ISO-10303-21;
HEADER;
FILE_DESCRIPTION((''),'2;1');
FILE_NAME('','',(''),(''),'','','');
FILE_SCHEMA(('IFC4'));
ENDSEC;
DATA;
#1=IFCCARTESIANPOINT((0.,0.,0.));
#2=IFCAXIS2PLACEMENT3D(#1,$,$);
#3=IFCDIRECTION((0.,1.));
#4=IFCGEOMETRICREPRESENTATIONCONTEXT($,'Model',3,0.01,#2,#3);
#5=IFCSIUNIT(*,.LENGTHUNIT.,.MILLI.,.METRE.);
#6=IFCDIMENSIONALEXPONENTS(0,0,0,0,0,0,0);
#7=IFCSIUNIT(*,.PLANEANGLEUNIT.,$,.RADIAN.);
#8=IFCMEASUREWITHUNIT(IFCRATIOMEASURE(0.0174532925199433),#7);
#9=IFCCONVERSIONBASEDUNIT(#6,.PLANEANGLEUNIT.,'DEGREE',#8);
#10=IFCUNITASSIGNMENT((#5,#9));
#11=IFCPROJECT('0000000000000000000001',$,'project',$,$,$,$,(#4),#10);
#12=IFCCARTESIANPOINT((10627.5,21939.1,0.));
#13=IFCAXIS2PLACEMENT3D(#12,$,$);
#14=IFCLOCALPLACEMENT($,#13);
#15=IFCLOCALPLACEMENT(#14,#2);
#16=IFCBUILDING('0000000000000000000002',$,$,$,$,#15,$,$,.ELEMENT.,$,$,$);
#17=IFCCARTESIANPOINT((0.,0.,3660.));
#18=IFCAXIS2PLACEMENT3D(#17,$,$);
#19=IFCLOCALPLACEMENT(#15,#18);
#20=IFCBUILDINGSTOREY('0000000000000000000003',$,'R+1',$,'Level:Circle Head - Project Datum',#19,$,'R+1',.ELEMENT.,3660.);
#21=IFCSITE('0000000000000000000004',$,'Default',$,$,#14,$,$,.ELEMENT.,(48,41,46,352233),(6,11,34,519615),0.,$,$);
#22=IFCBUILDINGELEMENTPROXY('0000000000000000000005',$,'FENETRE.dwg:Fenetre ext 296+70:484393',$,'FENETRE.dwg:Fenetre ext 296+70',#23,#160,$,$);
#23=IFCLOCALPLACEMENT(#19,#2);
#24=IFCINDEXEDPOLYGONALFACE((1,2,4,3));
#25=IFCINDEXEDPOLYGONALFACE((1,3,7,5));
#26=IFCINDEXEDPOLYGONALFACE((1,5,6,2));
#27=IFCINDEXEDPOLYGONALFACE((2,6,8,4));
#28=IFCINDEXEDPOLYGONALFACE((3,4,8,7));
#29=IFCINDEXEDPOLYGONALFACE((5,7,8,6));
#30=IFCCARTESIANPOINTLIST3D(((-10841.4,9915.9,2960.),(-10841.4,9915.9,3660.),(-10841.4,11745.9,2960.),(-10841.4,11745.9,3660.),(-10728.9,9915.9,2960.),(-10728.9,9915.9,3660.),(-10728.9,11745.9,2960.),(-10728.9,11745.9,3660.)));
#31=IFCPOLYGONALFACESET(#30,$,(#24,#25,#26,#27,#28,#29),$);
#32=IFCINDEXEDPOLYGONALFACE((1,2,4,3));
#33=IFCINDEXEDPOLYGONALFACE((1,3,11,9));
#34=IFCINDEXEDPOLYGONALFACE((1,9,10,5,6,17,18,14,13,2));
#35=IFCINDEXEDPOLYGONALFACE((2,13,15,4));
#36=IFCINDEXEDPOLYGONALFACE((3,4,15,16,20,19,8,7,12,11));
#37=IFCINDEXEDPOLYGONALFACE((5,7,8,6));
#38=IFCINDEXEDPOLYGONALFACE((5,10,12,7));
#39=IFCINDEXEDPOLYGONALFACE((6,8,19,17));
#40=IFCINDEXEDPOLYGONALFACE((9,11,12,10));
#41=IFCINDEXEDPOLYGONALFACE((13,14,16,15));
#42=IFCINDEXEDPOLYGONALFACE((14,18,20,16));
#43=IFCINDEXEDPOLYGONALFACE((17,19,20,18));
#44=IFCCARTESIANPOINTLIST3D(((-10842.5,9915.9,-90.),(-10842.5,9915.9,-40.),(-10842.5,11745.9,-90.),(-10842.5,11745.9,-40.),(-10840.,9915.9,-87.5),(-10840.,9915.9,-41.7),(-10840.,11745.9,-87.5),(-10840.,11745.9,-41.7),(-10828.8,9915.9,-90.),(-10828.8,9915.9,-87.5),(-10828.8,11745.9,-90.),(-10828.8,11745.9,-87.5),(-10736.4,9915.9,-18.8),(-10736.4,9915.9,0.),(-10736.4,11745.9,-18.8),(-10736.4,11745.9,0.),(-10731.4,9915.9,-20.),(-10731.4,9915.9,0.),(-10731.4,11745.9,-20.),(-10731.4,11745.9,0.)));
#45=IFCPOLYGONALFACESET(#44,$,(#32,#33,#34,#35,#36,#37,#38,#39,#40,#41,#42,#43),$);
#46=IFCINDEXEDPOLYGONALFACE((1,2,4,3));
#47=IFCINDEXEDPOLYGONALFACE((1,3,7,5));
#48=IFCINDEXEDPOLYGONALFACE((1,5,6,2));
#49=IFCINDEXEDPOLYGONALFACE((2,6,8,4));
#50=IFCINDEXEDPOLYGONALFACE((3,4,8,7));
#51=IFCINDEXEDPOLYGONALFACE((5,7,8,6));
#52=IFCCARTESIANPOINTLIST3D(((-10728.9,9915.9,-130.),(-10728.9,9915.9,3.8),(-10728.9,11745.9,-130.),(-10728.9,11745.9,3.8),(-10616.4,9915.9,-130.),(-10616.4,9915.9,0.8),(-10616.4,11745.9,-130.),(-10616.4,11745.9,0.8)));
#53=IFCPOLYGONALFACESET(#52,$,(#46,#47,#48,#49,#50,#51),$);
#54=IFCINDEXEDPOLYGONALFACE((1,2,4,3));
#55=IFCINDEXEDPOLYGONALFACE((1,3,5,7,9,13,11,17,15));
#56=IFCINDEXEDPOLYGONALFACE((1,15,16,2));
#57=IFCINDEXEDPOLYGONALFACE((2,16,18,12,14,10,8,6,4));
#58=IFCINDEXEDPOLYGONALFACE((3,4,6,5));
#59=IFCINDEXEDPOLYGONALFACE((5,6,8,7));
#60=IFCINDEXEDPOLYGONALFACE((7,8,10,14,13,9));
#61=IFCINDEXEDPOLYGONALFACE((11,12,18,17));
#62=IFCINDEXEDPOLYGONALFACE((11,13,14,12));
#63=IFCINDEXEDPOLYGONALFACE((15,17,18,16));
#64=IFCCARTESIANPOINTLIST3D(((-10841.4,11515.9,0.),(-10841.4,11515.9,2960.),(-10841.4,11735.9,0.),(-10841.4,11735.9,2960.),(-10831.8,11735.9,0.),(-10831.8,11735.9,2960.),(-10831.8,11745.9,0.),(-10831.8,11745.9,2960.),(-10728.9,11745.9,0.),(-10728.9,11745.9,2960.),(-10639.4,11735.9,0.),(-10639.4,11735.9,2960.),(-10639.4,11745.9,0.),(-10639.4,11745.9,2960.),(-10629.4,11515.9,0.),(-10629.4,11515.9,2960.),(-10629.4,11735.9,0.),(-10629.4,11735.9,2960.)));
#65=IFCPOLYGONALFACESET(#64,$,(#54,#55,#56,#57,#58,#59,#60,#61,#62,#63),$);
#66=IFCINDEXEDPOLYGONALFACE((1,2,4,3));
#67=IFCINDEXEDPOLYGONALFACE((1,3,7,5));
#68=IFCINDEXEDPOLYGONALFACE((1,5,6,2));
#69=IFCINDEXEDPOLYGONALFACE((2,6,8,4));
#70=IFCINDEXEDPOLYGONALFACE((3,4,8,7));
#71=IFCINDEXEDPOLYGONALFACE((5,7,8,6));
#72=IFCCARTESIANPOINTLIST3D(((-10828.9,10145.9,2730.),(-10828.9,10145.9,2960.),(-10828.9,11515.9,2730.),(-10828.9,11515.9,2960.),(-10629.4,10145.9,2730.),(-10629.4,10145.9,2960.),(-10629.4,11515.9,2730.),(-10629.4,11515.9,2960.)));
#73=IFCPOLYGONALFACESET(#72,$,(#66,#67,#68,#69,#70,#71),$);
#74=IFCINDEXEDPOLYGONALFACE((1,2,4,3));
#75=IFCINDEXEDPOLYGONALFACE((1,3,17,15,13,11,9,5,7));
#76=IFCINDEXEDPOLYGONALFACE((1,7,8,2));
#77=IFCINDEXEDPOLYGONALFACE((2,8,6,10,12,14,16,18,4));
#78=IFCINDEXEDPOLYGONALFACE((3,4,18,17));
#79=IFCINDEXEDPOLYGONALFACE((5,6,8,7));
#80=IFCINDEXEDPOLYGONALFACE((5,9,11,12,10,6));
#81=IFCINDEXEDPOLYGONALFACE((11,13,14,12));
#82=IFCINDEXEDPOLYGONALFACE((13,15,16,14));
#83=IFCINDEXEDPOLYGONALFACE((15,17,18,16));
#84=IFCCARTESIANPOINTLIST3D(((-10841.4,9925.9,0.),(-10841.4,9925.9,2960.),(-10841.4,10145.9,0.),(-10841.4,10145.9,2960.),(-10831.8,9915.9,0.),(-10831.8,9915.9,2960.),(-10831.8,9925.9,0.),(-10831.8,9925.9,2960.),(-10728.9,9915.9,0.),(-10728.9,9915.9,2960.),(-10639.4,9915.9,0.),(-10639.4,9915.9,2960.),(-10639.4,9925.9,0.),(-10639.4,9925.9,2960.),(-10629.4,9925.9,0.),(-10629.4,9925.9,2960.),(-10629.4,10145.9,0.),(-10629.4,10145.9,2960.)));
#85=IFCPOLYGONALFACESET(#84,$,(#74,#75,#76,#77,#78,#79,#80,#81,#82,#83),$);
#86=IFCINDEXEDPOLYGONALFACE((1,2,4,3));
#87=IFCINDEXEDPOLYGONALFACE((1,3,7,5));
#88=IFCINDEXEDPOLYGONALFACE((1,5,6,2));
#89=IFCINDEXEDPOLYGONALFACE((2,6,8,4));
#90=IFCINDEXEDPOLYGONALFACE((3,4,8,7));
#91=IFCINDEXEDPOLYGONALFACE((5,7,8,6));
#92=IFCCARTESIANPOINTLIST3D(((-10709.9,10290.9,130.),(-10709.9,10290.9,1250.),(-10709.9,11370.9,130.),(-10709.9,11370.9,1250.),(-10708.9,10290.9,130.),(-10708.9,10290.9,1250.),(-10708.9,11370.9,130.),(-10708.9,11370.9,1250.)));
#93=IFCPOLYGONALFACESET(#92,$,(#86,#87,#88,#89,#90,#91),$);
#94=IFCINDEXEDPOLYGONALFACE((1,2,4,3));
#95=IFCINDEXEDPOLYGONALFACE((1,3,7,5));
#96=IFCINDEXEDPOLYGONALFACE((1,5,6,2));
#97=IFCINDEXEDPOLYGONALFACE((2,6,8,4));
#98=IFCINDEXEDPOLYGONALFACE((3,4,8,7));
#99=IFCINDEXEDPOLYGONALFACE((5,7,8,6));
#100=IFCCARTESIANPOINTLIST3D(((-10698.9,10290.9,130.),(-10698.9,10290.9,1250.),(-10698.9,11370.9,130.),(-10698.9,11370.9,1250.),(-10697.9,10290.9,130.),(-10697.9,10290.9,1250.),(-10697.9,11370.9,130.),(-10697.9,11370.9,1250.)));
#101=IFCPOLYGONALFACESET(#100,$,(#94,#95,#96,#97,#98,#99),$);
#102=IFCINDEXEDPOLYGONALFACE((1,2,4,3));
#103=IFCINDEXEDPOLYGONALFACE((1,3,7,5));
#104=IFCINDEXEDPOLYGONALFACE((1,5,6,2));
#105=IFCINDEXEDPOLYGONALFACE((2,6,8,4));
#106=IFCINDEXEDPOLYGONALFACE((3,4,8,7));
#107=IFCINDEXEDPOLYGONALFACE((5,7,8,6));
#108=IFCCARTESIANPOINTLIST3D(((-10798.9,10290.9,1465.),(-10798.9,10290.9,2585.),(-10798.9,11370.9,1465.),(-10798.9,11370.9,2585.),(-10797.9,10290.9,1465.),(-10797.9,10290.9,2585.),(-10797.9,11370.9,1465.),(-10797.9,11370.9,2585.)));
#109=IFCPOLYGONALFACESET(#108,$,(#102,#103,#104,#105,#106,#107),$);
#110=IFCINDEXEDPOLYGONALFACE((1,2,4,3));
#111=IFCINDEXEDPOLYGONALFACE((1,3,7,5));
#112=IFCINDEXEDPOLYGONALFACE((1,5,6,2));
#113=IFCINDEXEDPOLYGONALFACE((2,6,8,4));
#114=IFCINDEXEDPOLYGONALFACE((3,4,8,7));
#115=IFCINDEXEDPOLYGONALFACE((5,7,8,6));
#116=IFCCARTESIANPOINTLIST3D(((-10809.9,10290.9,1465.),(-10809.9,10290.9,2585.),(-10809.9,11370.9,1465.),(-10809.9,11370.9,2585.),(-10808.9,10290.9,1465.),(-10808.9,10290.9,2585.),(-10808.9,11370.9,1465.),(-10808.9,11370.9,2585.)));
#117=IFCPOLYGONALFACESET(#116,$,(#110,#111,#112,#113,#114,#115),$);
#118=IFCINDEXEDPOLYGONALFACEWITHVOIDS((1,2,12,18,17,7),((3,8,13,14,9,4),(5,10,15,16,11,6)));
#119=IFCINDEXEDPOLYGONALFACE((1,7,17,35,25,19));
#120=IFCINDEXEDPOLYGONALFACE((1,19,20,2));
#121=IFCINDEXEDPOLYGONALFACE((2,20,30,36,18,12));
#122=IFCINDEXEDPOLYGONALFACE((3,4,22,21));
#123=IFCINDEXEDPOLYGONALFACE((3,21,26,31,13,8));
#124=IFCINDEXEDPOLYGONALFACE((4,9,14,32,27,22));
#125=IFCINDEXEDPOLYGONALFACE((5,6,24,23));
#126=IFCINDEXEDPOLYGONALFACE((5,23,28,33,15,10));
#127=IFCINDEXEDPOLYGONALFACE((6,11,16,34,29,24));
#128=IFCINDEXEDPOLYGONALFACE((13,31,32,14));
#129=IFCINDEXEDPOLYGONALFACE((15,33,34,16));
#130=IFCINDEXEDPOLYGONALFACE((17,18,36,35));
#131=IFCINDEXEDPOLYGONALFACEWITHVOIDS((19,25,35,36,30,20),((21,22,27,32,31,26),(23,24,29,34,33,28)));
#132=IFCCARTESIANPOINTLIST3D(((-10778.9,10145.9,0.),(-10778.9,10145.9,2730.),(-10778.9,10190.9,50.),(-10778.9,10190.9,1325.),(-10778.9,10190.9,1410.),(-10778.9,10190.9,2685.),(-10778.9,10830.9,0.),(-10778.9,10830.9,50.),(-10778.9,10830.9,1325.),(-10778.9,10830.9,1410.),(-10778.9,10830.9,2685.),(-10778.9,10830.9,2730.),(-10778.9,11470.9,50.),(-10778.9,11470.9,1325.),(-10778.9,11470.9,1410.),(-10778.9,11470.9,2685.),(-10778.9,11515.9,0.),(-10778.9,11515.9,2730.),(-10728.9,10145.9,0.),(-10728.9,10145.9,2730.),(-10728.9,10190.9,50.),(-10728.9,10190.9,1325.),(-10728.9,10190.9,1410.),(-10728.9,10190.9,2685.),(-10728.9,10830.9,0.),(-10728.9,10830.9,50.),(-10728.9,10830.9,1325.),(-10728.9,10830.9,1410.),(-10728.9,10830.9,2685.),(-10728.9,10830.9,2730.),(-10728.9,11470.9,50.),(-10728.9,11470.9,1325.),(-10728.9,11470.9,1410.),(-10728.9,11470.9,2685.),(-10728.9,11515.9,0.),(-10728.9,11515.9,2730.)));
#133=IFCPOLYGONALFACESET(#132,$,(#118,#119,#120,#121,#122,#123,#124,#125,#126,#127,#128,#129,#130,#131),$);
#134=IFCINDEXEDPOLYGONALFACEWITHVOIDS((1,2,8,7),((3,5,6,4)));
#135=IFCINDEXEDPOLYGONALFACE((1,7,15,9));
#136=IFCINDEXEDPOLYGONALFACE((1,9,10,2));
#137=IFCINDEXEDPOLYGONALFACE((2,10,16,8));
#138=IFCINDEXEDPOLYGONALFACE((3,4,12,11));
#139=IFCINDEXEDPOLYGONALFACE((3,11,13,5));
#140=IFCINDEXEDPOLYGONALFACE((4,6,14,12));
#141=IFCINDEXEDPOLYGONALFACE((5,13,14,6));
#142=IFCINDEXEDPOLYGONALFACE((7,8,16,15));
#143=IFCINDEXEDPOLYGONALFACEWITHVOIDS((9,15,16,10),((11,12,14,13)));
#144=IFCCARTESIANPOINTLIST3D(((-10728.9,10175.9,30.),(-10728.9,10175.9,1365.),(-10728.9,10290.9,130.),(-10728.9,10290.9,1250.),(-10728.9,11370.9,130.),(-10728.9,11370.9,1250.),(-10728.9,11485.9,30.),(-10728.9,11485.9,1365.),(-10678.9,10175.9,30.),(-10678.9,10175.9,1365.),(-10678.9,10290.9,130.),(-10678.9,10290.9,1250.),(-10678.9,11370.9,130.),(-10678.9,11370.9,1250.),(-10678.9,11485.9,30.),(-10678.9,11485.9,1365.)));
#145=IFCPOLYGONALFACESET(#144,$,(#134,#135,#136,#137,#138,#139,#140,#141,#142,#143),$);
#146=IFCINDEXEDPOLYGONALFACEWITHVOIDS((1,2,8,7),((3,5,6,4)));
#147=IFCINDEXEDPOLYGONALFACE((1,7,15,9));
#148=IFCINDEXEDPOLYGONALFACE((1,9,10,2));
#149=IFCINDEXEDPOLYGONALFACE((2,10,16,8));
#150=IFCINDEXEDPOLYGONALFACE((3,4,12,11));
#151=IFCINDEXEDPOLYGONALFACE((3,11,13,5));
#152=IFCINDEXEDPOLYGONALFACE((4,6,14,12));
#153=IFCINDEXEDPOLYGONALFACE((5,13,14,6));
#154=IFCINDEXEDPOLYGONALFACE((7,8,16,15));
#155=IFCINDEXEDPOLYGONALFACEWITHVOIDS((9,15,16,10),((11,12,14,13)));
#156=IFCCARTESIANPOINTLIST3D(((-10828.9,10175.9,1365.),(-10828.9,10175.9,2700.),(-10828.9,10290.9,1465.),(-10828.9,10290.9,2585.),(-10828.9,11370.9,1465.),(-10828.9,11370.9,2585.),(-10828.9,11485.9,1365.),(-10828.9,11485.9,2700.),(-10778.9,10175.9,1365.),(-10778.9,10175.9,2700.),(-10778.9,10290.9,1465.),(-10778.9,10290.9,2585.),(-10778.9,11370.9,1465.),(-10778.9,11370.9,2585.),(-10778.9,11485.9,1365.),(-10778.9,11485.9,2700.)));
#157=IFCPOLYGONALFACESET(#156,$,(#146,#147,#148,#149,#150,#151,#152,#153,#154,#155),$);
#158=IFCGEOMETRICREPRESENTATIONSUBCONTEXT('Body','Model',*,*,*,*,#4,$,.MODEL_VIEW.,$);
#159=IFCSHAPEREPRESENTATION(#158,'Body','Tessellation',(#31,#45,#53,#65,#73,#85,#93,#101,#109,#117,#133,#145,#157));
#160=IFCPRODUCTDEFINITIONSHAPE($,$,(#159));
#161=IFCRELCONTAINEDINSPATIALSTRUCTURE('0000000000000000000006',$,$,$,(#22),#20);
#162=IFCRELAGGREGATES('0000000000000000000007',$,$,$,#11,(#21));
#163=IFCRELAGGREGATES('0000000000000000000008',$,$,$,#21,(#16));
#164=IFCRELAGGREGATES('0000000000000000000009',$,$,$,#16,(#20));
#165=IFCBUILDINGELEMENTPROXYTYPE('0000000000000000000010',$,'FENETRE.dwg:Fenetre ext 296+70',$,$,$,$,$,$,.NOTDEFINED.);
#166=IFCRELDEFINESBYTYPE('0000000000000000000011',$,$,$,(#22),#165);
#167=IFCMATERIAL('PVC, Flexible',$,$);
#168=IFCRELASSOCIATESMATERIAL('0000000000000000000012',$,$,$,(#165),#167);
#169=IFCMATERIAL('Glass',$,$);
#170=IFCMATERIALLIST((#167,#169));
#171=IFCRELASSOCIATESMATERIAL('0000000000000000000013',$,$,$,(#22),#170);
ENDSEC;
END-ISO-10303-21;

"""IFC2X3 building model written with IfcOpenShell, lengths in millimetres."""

from ifc_helpers import new_model, entity, si_unit, converted_unit, direction, frame, frame_2d, origin, origin_2d_with_axis, place, context, subcontext, project, spatial, polyline, rectangle, outline, extrude, source, transform, mapped, material, material_list, type_object, type_shapes, element, save


model = new_model("IFC2X3")

# Units and contexts
model_context = context("Model", 3, precision=0.01, world=origin(), true_north=direction((0.0, 1.0)))
body_context = subcontext(model_context, "Body", "Model", "MODEL_VIEW")
ifc_project = project(units=[si_unit("LENGTHUNIT", "METRE", prefix="MILLI"), converted_unit("PLANEANGLEUNIT", "DEGREE", entity("IfcRatioMeasure", 0.0174532925199433), si_unit("PLANEANGLEUNIT", "RADIAN"), dimensions=[0, 0, 0, 0, 0, 0, 0])], contexts=[model_context])

# Site, building, storey
site_placement = place(None, frame((10627.5, 21939.1, 0.0)))
site = spatial("IfcSite", under=ifc_project, at=site_placement, Name="Default", CompositionType="ELEMENT", RefLatitude=(48, 41, 46, 352233), RefLongitude=(6, 11, 34, 519615), RefElevation=0.0)
building_placement = place(site_placement, origin())
building = spatial("IfcBuilding", under=site, at=building_placement, CompositionType="ELEMENT")
storey_placement = place(building_placement, frame((0.0, 0.0, 3660.0)))
storey = spatial("IfcBuildingStorey", under=building, at=storey_placement, Name="R+1", ObjectType="Level:Circle Head - Project Datum", LongName="R+1", CompositionType="ELEMENT", Elevation=3660.0)

# Building element proxy
ifc_material_1 = material(Name="PVC, Flexible")
ifc_material_2 = material(Name="Glass")
building_element_proxy_type_1 = type_object("IfcBuildingElementProxyType", Name="FENETRE.dwg:Fenetre ext 296+70", PredefinedType="NOTDEFINED", material=ifc_material_1)
shared_shape_1 = source(origin(), body_context, "Body", "SweptSolid", [
    extrude(rectangle(XDim=1830.0, YDim=112.5, at=origin_2d_with_axis()), frame((-10.4, 56.3, 2960.0), z_axis=(0.0, 0.0, 1.0), x_axis=(-1.0, 0.0, 0.0)), (0.0, 0.0, 1.0), 700.0),
    extrude(outline(polyline([(-68.6, -14.4), (-72.5, -34.0), (-67.6, -35.0), (-63.9, -16.6), (44.3, -16.6), (54.1, 32.5), (40.6, 35.2), (40.1, 32.7), (51.2, 30.5), (42.2, -14.4), (-68.6, -14.4)])), frame((-925.4, 66.9, -47.5), z_axis=(-1.0, 0.0, 0.0), x_axis=(0.0, 0.980599, -0.196027)), (0.0, 0.0, -1.0), 1830.0),
    extrude(outline(polyline([(-64.7, -56.3), (66.2, -56.3), (66.2, 56.3), (-67.7, 56.3), (-64.7, -56.3)])), frame((-925.4, -56.3, -63.8), z_axis=(1.0, 0.0, 0.0), x_axis=(0.0, 0.0, -1.0)), (0.0, 0.0, 1.0), 1830.0),
    extrude(outline(polyline([(-55.6, 97.0), (-55.6, -5.9), (-55.6, -95.4), (-45.6, -95.4), (-45.6, -105.4), (174.4, -105.4), (174.4, 106.6), (-45.6, 106.6), (-45.6, 97.0), (-55.6, 97.0)])), frame((849.0, 5.9, 0.0), z_axis=(0.0, 0.0, -1.0), x_axis=(-1.0, 0.0, 0.0)), (0.0, 0.0, -1.0), 2960.0),
    extrude(rectangle(XDim=199.5, YDim=1370.0, at=origin_2d_with_axis()), frame((-10.4, 0.3, 2730.0), z_axis=(0.0, 0.0, 1.0), x_axis=(0.0, 1.0, 0.0)), (0.0, 0.0, 1.0), 230.0),
    extrude(outline(polyline([(-97.0, -55.6), (5.9, -55.6), (95.4, -55.6), (95.4, -45.6), (105.4, -45.6), (105.4, 174.4), (-106.6, 174.4), (-106.6, -45.6), (-97.0, -45.6), (-97.0, -55.6)])), frame((-869.9, 5.9, 0.0), z_axis=(0.0, 0.0, 1.0), x_axis=(0.0, -1.0, 0.0)), (0.0, 0.0, 1.0), 2960.0),
    extrude(rectangle(XDim=1.0, YDim=1080.0, at=origin_2d_with_axis()), frame((-10.4, -19.5, 130.0), z_axis=(0.0, 0.0, 1.0), x_axis=(0.0, 1.0, 0.0)), (0.0, 0.0, 1.0), 1120.0),
    extrude(rectangle(XDim=1.0, YDim=1080.0, at=frame_2d((0.0, 0.0), x_axis=(1.0, 0.0))), frame((-10.4, -30.5, 130.0), z_axis=(0.0, 0.0, 1.0), x_axis=(0.0, 1.0, 0.0)), (0.0, 0.0, 1.0), 1120.0),
    extrude(rectangle(XDim=1.0, YDim=1080.0, at=frame_2d((0.0, 0.0), x_axis=(1.0, 0.0))), frame((-10.4, 69.5, 1465.0), z_axis=(0.0, 0.0, 1.0), x_axis=(0.0, 1.0, 0.0)), (0.0, 0.0, 1.0), 1120.0),
    extrude(rectangle(XDim=1.0, YDim=1080.0, at=frame_2d((0.0, 0.0), x_axis=(1.0, 0.0))), frame((-10.4, 80.5, 1465.0), z_axis=(0.0, 0.0, 1.0), x_axis=(0.0, 1.0, 0.0)), (0.0, 0.0, 1.0), 1120.0),
    extrude(outline(polyline([(-685.0, -1365.0), (0.0, -1365.0), (685.0, -1365.0), (685.0, 1365.0), (0.0, 1365.0), (-685.0, 1365.0), (-685.0, -1365.0)]), holes=[polyline([(-640.0, -1320.0), (-640.0, -45.0), (0.0, -45.0), (640.0, -45.0), (640.0, -1320.0), (0.0, -1320.0), (-640.0, -1320.0)]), polyline([(-640.0, 40.0), (-640.0, 1315.0), (0.0, 1315.0), (640.0, 1315.0), (640.0, 40.0), (0.0, 40.0), (-640.0, 40.0)])]), frame((-10.4, 0.0, 1365.0), z_axis=(0.0, 1.0, 0.0), x_axis=(1.0, 0.0, 0.0)), (0.0, 0.0, 1.0), 50.0),
    extrude(outline(polyline([(-655.0, -667.5), (655.0, -667.5), (655.0, 667.5), (-655.0, 667.5), (-655.0, -667.5)]), holes=[polyline([(-540.0, 552.5), (540.0, 552.5), (540.0, -567.5), (-540.0, -567.5), (-540.0, 552.5)])]), frame((-10.4, -50.0, 697.5), z_axis=(0.0, 1.0, 0.0), x_axis=(-1.0, 0.0, 0.0)), (0.0, 0.0, 1.0), 50.0),
    extrude(outline(polyline([(-655.0, -667.5), (655.0, -667.5), (655.0, 667.5), (-655.0, 667.5), (-655.0, -667.5)]), holes=[polyline([(-540.0, 552.5), (540.0, 552.5), (540.0, -567.5), (-540.0, -567.5), (-540.0, 552.5)])]), frame((-10.4, 50.0, 2032.5), z_axis=(0.0, 1.0, 0.0), x_axis=(-1.0, 0.0, 0.0)), (0.0, 0.0, 1.0), 50.0),
])
type_shapes(building_element_proxy_type_1, [shared_shape_1])
ifc_material_list_1 = material_list([ifc_material_1, ifc_material_2])
proxy_1_placement = place(storey_placement, frame((-10728.9, 10841.3, 0.0), z_axis=(0.0, 0.0, 1.0), x_axis=(0.0, 1.0, 0.0)))
element("IfcBuildingElementProxy", 1, at=proxy_1_placement, inside=storey, type_object=building_element_proxy_type_1, material=ifc_material_list_1, Name="FENETRE.dwg:Fenetre ext 296+70:484393", ObjectType="FENETRE.dwg:Fenetre ext 296+70", context=body_context, shape_type="MappedRepresentation", body=[
    mapped(shared_shape_1, transform((0.0, 0.0, 0.0), scale=1.0)),
])

save(model, "model.ifc")
